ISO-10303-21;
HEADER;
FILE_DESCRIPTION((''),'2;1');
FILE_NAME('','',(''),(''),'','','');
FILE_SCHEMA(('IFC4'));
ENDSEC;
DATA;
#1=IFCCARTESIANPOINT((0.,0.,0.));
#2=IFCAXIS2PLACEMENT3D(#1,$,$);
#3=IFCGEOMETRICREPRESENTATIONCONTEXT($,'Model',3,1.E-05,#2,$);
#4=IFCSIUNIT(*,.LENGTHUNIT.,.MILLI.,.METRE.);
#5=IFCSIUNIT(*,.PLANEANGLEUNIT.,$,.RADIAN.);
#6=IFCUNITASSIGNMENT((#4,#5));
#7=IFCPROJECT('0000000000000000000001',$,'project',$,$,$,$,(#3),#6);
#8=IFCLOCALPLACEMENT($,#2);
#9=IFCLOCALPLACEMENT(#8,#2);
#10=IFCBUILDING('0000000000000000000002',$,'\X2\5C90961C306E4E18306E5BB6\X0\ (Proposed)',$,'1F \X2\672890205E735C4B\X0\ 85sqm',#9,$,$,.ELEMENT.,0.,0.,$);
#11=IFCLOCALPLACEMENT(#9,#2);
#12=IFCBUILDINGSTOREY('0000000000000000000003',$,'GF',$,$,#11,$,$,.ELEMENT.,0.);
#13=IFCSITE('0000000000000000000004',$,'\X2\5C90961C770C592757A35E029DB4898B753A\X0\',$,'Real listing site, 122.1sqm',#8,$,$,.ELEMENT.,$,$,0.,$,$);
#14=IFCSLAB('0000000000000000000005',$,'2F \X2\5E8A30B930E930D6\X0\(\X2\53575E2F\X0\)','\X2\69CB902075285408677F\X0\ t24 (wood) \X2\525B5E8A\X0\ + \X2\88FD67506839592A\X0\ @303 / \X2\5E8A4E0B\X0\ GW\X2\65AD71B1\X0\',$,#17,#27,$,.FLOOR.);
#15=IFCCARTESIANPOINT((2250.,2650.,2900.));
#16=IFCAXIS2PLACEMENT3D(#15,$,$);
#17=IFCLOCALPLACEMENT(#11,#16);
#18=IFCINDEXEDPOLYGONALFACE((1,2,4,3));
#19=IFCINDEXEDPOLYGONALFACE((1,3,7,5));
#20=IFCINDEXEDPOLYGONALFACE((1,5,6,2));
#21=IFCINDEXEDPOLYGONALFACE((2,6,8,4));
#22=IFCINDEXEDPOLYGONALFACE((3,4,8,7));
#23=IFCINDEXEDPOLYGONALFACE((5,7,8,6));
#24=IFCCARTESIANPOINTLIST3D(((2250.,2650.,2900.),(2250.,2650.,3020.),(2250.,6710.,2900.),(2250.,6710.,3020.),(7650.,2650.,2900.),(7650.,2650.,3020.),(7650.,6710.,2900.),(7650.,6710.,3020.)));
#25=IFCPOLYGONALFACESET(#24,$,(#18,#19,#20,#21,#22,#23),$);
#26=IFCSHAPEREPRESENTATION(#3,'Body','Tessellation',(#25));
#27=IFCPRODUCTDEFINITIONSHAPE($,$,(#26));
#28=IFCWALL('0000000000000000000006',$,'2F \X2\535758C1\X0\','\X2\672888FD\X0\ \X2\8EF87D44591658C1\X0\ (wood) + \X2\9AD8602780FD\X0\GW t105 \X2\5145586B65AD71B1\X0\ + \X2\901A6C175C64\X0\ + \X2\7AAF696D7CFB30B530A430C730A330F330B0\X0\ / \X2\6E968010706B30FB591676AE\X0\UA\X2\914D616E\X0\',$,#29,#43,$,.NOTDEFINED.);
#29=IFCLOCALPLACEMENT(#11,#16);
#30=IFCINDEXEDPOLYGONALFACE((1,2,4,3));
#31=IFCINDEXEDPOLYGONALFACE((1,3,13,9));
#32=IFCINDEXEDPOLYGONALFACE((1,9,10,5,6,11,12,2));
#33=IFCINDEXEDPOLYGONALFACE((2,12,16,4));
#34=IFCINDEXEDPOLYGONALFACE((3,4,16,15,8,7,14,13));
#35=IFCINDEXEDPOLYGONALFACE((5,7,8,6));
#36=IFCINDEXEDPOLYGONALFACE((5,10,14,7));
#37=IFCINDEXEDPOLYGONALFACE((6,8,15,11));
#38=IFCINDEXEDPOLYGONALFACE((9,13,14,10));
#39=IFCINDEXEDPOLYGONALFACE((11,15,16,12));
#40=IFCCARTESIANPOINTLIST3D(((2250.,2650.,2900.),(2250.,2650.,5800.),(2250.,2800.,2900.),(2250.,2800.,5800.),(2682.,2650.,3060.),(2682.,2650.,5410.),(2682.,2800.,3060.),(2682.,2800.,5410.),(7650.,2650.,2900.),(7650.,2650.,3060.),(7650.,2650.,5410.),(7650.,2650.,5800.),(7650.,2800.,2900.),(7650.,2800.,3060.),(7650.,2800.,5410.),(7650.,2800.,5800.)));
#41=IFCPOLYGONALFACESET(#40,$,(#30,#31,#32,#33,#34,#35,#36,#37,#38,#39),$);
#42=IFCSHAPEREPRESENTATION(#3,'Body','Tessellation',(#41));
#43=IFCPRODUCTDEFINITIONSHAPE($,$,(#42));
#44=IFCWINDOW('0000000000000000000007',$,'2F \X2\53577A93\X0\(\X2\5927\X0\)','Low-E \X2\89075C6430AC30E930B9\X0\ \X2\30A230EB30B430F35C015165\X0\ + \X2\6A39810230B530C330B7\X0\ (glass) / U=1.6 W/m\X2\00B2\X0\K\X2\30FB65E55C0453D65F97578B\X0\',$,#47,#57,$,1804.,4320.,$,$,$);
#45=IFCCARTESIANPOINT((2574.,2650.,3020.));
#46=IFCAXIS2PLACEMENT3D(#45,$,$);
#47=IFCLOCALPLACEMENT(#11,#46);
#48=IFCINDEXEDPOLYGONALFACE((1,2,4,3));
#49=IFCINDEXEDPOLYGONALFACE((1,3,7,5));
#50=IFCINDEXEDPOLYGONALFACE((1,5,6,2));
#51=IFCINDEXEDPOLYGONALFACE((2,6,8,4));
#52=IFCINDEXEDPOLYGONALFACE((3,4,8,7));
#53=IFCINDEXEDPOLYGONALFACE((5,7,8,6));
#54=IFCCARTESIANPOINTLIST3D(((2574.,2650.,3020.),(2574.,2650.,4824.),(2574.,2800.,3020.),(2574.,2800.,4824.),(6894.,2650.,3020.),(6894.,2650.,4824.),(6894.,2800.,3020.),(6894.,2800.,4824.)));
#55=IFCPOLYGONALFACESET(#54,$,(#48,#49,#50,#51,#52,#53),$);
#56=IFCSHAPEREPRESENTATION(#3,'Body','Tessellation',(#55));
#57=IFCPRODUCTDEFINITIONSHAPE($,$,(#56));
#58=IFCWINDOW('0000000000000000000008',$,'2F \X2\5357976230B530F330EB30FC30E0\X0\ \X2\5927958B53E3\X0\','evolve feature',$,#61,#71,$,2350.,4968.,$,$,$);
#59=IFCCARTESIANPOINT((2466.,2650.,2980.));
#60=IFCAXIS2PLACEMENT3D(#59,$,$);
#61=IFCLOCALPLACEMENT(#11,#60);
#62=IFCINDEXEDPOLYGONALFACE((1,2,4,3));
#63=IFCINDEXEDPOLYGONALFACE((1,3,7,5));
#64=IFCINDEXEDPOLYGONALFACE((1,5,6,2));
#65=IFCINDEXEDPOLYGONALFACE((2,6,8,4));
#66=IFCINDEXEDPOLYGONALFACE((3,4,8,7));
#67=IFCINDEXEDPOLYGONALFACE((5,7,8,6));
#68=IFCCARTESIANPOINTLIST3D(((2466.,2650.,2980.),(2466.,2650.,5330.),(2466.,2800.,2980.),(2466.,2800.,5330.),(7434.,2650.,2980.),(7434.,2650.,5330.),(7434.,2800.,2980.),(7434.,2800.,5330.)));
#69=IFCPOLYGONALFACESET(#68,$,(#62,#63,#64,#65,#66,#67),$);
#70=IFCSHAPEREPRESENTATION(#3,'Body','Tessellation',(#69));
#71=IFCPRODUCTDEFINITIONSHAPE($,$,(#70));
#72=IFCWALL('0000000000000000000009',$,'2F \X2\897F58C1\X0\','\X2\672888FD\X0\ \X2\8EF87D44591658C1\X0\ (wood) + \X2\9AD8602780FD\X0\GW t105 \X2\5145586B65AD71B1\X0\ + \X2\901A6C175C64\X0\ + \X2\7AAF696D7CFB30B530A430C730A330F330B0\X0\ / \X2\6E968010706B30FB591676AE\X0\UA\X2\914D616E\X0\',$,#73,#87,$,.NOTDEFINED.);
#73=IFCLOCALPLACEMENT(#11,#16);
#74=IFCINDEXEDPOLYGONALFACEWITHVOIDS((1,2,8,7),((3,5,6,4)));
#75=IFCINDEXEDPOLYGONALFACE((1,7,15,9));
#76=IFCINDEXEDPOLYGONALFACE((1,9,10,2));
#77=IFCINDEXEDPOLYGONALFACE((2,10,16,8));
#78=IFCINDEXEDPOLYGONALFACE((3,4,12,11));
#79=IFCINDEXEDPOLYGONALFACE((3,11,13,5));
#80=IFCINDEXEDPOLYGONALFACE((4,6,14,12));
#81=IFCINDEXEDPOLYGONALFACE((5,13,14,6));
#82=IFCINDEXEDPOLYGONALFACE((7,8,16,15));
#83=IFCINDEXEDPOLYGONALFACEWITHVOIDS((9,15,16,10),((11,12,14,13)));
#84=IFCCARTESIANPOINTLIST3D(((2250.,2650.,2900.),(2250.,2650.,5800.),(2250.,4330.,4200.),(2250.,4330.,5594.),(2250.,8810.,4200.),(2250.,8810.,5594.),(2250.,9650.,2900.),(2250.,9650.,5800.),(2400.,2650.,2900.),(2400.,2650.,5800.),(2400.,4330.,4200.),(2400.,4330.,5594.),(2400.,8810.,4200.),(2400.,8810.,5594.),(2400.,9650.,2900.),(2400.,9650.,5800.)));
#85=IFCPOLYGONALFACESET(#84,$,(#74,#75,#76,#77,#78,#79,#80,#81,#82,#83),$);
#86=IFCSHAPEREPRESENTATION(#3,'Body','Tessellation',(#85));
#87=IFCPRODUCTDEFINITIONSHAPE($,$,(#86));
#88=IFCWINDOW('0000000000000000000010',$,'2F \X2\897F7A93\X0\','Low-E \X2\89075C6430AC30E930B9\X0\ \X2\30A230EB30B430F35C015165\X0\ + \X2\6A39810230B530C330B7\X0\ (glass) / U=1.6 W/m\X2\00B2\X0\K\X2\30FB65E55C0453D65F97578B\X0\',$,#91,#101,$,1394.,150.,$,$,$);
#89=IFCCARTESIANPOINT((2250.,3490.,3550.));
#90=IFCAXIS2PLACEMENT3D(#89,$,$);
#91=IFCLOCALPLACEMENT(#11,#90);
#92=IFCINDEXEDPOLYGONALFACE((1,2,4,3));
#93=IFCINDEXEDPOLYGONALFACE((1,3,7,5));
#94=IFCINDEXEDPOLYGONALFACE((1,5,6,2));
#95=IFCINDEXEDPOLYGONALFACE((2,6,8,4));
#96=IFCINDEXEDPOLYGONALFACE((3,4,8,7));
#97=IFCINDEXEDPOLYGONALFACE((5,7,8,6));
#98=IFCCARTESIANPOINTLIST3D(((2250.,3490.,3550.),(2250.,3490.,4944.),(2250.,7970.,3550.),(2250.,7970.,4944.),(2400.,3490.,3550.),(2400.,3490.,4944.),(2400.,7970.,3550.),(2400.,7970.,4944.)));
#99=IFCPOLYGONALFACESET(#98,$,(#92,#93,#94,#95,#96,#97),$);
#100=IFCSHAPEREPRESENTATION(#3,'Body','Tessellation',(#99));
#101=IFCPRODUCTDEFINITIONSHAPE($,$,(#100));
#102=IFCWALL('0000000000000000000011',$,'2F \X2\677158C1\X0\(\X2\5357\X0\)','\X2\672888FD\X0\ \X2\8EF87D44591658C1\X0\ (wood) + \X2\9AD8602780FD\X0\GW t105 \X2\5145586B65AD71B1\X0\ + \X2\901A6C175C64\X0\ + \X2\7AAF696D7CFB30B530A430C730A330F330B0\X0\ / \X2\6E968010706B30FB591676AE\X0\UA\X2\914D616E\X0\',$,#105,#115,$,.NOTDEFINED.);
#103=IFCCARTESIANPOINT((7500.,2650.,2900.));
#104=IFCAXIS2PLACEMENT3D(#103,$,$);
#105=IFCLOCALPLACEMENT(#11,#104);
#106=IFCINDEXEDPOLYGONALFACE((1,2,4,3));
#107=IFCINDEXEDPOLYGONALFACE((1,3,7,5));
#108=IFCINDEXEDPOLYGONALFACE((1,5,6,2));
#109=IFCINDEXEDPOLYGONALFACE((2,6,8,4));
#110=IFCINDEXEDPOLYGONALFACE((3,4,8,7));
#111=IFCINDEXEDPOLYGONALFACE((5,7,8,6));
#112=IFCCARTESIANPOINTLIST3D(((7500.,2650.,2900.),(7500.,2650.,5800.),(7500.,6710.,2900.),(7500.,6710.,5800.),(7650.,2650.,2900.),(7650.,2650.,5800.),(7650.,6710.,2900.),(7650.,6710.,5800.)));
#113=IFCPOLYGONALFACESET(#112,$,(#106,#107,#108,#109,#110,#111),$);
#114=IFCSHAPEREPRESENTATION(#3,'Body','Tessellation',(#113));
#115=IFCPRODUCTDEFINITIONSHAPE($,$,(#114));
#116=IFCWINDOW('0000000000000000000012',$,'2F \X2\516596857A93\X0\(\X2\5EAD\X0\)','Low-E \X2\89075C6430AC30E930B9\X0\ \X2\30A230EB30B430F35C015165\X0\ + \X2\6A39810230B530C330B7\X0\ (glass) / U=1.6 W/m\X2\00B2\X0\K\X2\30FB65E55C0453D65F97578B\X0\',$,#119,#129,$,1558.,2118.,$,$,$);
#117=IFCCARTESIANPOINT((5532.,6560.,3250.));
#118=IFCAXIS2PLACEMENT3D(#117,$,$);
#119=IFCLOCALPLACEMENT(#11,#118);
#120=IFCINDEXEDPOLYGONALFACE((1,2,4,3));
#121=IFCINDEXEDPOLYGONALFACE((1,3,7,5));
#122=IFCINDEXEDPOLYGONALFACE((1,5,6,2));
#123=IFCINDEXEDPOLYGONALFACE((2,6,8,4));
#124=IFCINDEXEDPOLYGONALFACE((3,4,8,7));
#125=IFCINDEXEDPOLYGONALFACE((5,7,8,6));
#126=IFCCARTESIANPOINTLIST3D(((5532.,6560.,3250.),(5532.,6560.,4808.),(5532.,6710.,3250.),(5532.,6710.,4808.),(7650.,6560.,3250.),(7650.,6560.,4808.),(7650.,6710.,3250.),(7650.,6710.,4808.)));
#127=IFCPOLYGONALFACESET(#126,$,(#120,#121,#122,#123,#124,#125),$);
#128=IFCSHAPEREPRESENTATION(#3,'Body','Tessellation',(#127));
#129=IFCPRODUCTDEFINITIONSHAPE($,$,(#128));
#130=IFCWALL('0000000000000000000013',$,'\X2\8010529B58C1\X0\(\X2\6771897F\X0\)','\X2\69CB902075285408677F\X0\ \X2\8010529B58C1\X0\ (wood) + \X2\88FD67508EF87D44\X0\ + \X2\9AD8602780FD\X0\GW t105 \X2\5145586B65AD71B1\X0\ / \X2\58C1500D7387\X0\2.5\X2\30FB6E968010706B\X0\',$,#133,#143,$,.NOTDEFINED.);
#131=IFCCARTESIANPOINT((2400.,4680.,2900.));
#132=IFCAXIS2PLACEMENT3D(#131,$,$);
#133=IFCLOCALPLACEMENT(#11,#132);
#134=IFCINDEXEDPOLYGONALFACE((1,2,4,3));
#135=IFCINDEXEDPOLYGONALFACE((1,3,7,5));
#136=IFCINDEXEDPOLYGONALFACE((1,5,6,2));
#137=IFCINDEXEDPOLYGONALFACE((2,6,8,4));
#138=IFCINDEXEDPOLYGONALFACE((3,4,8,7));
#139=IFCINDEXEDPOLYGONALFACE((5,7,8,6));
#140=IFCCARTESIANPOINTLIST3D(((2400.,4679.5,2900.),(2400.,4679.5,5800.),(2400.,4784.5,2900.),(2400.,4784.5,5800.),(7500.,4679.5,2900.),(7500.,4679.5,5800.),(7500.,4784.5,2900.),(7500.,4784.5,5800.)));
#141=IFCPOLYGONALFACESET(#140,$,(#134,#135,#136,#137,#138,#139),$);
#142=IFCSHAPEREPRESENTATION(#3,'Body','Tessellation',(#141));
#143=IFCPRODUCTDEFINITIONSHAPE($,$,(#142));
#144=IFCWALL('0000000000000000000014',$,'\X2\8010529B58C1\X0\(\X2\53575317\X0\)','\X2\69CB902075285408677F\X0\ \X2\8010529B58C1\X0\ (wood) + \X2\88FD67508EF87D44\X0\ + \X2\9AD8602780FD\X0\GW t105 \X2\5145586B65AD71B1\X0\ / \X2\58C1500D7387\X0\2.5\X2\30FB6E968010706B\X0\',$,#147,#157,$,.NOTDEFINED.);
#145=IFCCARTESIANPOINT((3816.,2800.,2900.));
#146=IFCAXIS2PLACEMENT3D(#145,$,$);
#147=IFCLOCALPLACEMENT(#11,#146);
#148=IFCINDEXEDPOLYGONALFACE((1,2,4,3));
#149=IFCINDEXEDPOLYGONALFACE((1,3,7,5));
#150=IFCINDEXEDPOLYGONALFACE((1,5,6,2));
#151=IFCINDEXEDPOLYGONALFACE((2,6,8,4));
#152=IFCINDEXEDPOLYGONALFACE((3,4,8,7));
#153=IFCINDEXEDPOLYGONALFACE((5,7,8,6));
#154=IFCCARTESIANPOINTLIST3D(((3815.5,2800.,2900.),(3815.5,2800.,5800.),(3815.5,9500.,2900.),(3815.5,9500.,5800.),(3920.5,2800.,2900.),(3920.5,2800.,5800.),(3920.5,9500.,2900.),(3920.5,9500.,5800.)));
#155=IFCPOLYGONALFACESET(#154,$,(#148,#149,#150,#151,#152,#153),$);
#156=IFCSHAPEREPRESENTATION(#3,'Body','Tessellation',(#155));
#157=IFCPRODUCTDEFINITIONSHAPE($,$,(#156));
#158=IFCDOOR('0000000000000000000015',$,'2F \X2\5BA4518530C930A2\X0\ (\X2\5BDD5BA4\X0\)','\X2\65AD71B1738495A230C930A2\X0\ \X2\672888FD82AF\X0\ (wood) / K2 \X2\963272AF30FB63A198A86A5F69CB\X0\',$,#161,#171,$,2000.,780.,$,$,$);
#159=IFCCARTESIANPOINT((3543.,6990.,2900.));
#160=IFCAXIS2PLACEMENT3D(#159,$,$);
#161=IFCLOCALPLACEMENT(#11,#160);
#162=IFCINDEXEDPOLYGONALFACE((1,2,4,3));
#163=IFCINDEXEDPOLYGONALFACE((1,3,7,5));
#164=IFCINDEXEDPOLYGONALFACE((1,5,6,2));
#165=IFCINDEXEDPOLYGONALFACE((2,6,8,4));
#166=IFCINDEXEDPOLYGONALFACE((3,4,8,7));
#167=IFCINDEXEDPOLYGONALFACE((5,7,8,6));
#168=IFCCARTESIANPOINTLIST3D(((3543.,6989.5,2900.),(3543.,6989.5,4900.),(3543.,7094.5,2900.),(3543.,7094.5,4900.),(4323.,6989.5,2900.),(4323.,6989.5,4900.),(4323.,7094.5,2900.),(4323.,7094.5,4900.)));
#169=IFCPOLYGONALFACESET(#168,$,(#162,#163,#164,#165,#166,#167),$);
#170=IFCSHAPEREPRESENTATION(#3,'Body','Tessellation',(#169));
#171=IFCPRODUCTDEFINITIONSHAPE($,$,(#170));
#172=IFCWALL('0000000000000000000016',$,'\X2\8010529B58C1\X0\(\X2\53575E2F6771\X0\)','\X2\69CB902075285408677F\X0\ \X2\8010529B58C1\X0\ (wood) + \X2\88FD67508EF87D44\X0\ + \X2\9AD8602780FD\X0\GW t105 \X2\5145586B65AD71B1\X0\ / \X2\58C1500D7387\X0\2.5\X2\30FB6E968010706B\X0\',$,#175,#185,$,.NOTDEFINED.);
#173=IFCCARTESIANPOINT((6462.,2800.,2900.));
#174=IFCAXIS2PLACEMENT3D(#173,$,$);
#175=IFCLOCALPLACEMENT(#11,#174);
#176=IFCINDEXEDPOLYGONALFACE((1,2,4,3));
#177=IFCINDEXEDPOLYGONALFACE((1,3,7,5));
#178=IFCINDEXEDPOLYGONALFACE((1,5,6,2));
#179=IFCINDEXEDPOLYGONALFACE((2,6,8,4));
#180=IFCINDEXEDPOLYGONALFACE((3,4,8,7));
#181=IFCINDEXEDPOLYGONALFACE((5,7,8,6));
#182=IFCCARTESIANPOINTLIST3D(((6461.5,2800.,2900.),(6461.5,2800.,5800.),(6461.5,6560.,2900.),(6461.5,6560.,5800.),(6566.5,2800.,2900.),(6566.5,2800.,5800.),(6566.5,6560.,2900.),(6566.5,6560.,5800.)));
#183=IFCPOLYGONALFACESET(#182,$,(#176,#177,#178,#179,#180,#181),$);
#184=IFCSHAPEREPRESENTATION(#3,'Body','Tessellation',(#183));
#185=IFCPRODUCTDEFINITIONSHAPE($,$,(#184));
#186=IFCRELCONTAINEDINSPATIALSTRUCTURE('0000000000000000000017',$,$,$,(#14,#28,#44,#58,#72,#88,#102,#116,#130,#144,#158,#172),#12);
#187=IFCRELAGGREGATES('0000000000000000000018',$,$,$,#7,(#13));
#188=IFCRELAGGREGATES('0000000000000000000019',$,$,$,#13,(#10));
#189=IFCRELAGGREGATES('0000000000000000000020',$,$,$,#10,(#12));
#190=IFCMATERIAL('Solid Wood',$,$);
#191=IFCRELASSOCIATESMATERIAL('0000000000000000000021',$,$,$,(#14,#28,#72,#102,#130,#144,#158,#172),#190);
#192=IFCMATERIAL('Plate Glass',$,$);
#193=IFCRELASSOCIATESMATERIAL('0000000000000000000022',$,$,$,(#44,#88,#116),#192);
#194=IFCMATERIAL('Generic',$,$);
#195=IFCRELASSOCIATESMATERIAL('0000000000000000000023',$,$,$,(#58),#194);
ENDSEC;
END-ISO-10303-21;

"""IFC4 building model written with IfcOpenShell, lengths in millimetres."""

from ifc_helpers import new_model, si_unit, frame, frame_2d, origin, place, context, project, spatial, rectangle, extrude, material, element, fill, save


model = new_model("IFC4")

# Units and contexts
model_context = context("Model", 3, precision=1e-05, world=origin())
ifc_project = project(units=[si_unit("LENGTHUNIT", "METRE", prefix="MILLI"), si_unit("PLANEANGLEUNIT", "RADIAN")], contexts=[model_context])

# Site, building, storey
site_placement = place(None, origin())
site = spatial("IfcSite", under=ifc_project, at=site_placement, Name="岐阜県大垣市鶴見町", ObjectType="Real listing site, 122.1sqm", CompositionType="ELEMENT", RefElevation=0.0)
building_placement = place(site_placement, origin())
building = spatial("IfcBuilding", under=site, at=building_placement, Name="岐阜の丘の家 (Proposed)", ObjectType="1F 木造平屋 85sqm", CompositionType="ELEMENT", ElevationOfRefHeight=0.0, ElevationOfTerrain=0.0)
storey_placement = place(building_placement, origin())
storey = spatial("IfcBuildingStorey", under=building, at=storey_placement, Name="GF", CompositionType="ELEMENT", Elevation=0.0)

# Slab
ifc_material_1 = material(Name="Solid Wood")
slab_placement = place(storey_placement, frame((2250.0, 2650.0, 2900.0)))
element("IfcSlab", 1, at=slab_placement, inside=storey, material=ifc_material_1, Name="2F 床スラブ(南帯)", Description="構造用合板 t24 (wood) 剛床 + 製材根太 @303 / 床下 GW断熱", PredefinedType="FLOOR", context=model_context, shape_type="SweptSolid", body=[
    extrude(rectangle(XDim=5400.0, YDim=4060.0, at=frame_2d((2700.0, 2030.0))), frame((2250.0, 2650.0, 2900.0)), (0.0, 0.0, 1.0), 120.0),
])

# Wall, openings, windows
wall_1_placement = place(storey_placement, frame((2250.0, 2650.0, 2900.0)))
wall_1 = element("IfcWall", 2, at=wall_1_placement, inside=storey, material=ifc_material_1, Name="2F 南壁", Description="木製 軸組外壁 (wood) + 高性能GW t105 充填断熱 + 通気層 + 窯業系サイディング / 準耐火・外皮UA配慮", PredefinedType="NOTDEFINED", context=model_context, shape_type="SweptSolid", body=[
    extrude(rectangle(XDim=5400.0, YDim=150.0, at=frame_2d((2700.0, 75.0))), frame((2250.0, 2650.0, 2900.0)), (0.0, 0.0, 1.0), 2900.0),
])
opening_1_placement = place(storey_placement, frame((2574.0, 2650.0, 3020.0)))
opening_1 = element("IfcOpeningElement", 3, at=opening_1_placement, cuts=wall_1, PredefinedType="NOTDEFINED", context=model_context, shape_type="SweptSolid", body=[
    extrude(rectangle(XDim=4320.0, YDim=150.0, at=frame_2d((2160.0, 75.0))), frame((2574.0, 2650.0, 3020.0)), (0.0, 0.0, 1.0), 1804.0),
])
opening_2_placement = place(storey_placement, frame((2466.0, 2650.0, 2980.0)))
opening_2 = element("IfcOpeningElement", 4, at=opening_2_placement, cuts=wall_1, PredefinedType="NOTDEFINED", context=model_context, shape_type="SweptSolid", body=[
    extrude(rectangle(XDim=4968.0, YDim=150.0, at=frame_2d((2484.0, 75.0))), frame((2466.0, 2650.0, 2980.0)), (0.0, 0.0, 1.0), 2350.0),
])
ifc_material_2 = material(Name="Plate Glass")
window_1_placement = place(storey_placement, frame((2574.0, 2650.0, 3020.0)))
window_1 = element("IfcWindow", 5, at=window_1_placement, inside=storey, material=ifc_material_2, Name="2F 南窓(大)", Description="Low-E 複層ガラス アルゴン封入 + 樹脂サッシ (glass) / U=1.6 W/m²K・日射取得型", OverallHeight=1804.0, OverallWidth=4320.0, context=model_context, shape_type="SweptSolid", body=[
    extrude(rectangle(XDim=4320.0, YDim=150.0, at=frame_2d((2160.0, 75.0))), frame((2574.0, 2650.0, 3020.0)), (0.0, 0.0, 1.0), 1804.0),
])
fill(opening_1, window_1)
ifc_material_3 = material(Name="Generic")
window_2_placement = place(storey_placement, frame((2466.0, 2650.0, 2980.0)))
window_2 = element("IfcWindow", 6, at=window_2_placement, inside=storey, material=ifc_material_3, Name="2F 南面サンルーム 大開口", Description="evolve feature", OverallHeight=2350.0, OverallWidth=4968.0, context=model_context, shape_type="SweptSolid", body=[
    extrude(rectangle(XDim=4968.0, YDim=150.0, at=frame_2d((2484.0, 75.0))), frame((2466.0, 2650.0, 2980.0)), (0.0, 0.0, 1.0), 2350.0),
])
fill(opening_2, window_2)

# Walls, openings, windows
wall_2_placement = place(storey_placement, frame((2250.0, 2650.0, 2900.0)))
wall_2 = element("IfcWall", 7, at=wall_2_placement, inside=storey, material=ifc_material_1, Name="2F 西壁", Description="木製 軸組外壁 (wood) + 高性能GW t105 充填断熱 + 通気層 + 窯業系サイディング / 準耐火・外皮UA配慮", PredefinedType="NOTDEFINED", context=model_context, shape_type="SweptSolid", body=[
    extrude(rectangle(XDim=150.0, YDim=7000.0, at=frame_2d((75.0, 3500.0))), frame((2250.0, 2650.0, 2900.0)), (0.0, 0.0, 1.0), 2900.0),
])
opening_3_placement = place(storey_placement, frame((2250.0, 3490.0, 3550.0)))
opening_3 = element("IfcOpeningElement", 8, at=opening_3_placement, cuts=wall_2, PredefinedType="NOTDEFINED", context=model_context, shape_type="SweptSolid", body=[
    extrude(rectangle(XDim=150.0, YDim=4480.0, at=frame_2d((75.0, 2240.0))), frame((2250.0, 3490.0, 3550.0)), (0.0, 0.0, 1.0), 1394.0),
])
window_3_placement = place(storey_placement, frame((2250.0, 3490.0, 3550.0)))
window_3 = element("IfcWindow", 9, at=window_3_placement, inside=storey, material=ifc_material_2, Name="2F 西窓", Description="Low-E 複層ガラス アルゴン封入 + 樹脂サッシ (glass) / U=1.6 W/m²K・日射取得型", OverallHeight=1394.0, OverallWidth=150.0, context=model_context, shape_type="SweptSolid", body=[
    extrude(rectangle(XDim=150.0, YDim=4480.0, at=frame_2d((75.0, 2240.0))), frame((2250.0, 3490.0, 3550.0)), (0.0, 0.0, 1.0), 1394.0),
])
fill(opening_3, window_3)
wall_3_placement = place(storey_placement, frame((7500.0, 2650.0, 2900.0)))
wall_3 = element("IfcWall", 10, at=wall_3_placement, inside=storey, material=ifc_material_1, Name="2F 東壁(南)", Description="木製 軸組外壁 (wood) + 高性能GW t105 充填断熱 + 通気層 + 窯業系サイディング / 準耐火・外皮UA配慮", PredefinedType="NOTDEFINED", context=model_context, shape_type="SweptSolid", body=[
    extrude(rectangle(XDim=150.0, YDim=4060.0, at=frame_2d((75.0, 2030.0))), frame((7500.0, 2650.0, 2900.0)), (0.0, 0.0, 1.0), 2900.0),
])
opening_4_placement = place(storey_placement, frame((5532.0, 6560.0, 3250.0)))
opening_4 = element("IfcOpeningElement", 11, at=opening_4_placement, cuts=wall_3, PredefinedType="NOTDEFINED", context=model_context, shape_type="SweptSolid", body=[
    extrude(rectangle(XDim=2118.0, YDim=150.0, at=frame_2d((1059.0, 75.0))), frame((5532.0, 6560.0, 3250.0)), (0.0, 0.0, 1.0), 1558.0),
])
window_4_placement = place(storey_placement, frame((5532.0, 6560.0, 3250.0)))
window_4 = element("IfcWindow", 12, at=window_4_placement, inside=storey, material=ifc_material_2, Name="2F 入隅窓(庭)", Description="Low-E 複層ガラス アルゴン封入 + 樹脂サッシ (glass) / U=1.6 W/m²K・日射取得型", OverallHeight=1558.0, OverallWidth=2118.0, context=model_context, shape_type="SweptSolid", body=[
    extrude(rectangle(XDim=2118.0, YDim=150.0, at=frame_2d((1059.0, 75.0))), frame((5532.0, 6560.0, 3250.0)), (0.0, 0.0, 1.0), 1558.0),
])
fill(opening_4, window_4)

# Wall
wall_4_placement = place(storey_placement, frame((2400.0, 4680.0, 2900.0)))
element("IfcWall", 13, at=wall_4_placement, inside=storey, material=ifc_material_1, Name="耐力壁(東西)", Description="構造用合板 耐力壁 (wood) + 製材軸組 + 高性能GW t105 充填断熱 / 壁倍率2.5・準耐火", PredefinedType="NOTDEFINED", context=model_context, shape_type="SweptSolid", body=[
    extrude(rectangle(XDim=5100.0, YDim=105.0, at=frame_2d((2550.0, 52.0))), frame((2400.0, 4680.0, 2900.0)), (0.0, 0.0, 1.0), 2900.0),
])

# Wall, opening, door
wall_5_placement = place(storey_placement, frame((3816.0, 2800.0, 2900.0)))
wall_5 = element("IfcWall", 14, at=wall_5_placement, inside=storey, material=ifc_material_1, Name="耐力壁(南北)", Description="構造用合板 耐力壁 (wood) + 製材軸組 + 高性能GW t105 充填断熱 / 壁倍率2.5・準耐火", PredefinedType="NOTDEFINED", context=model_context, shape_type="SweptSolid", body=[
    extrude(rectangle(XDim=105.0, YDim=6700.0, at=frame_2d((52.0, 3350.0))), frame((3816.0, 2800.0, 2900.0)), (0.0, 0.0, 1.0), 2900.0),
])
opening_5_placement = place(storey_placement, frame((3543.0, 6990.0, 2900.0)))
opening_5 = element("IfcOpeningElement", 15, at=opening_5_placement, cuts=wall_5, PredefinedType="NOTDEFINED", context=model_context, shape_type="SweptSolid", body=[
    extrude(rectangle(XDim=780.0, YDim=105.0, at=frame_2d((390.0, 52.0))), frame((3543.0, 6990.0, 2900.0)), (0.0, 0.0, 1.0), 2000.0),
])
door_placement = place(storey_placement, frame((3543.0, 6990.0, 2900.0)))
door = element("IfcDoor", 16, at=door_placement, inside=storey, material=ifc_material_1, Name="2F 室内ドア (寝室)", Description="断熱玄関ドア 木製芯 (wood) / K2 防犯・採風機構", OverallHeight=2000.0, OverallWidth=780.0, context=model_context, shape_type="SweptSolid", body=[
    extrude(rectangle(XDim=780.0, YDim=105.0, at=frame_2d((390.0, 52.0))), frame((3543.0, 6990.0, 2900.0)), (0.0, 0.0, 1.0), 2000.0),
])
fill(opening_5, door)

# Wall
wall_6_placement = place(storey_placement, frame((6462.0, 2800.0, 2900.0)))
element("IfcWall", 17, at=wall_6_placement, inside=storey, material=ifc_material_1, Name="耐力壁(南帯東)", Description="構造用合板 耐力壁 (wood) + 製材軸組 + 高性能GW t105 充填断熱 / 壁倍率2.5・準耐火", PredefinedType="NOTDEFINED", context=model_context, shape_type="SweptSolid", body=[
    extrude(rectangle(XDim=105.0, YDim=3760.0, at=frame_2d((52.0, 1880.0))), frame((6462.0, 2800.0, 2900.0)), (0.0, 0.0, 1.0), 2900.0),
])

save(model, "model.ifc")
